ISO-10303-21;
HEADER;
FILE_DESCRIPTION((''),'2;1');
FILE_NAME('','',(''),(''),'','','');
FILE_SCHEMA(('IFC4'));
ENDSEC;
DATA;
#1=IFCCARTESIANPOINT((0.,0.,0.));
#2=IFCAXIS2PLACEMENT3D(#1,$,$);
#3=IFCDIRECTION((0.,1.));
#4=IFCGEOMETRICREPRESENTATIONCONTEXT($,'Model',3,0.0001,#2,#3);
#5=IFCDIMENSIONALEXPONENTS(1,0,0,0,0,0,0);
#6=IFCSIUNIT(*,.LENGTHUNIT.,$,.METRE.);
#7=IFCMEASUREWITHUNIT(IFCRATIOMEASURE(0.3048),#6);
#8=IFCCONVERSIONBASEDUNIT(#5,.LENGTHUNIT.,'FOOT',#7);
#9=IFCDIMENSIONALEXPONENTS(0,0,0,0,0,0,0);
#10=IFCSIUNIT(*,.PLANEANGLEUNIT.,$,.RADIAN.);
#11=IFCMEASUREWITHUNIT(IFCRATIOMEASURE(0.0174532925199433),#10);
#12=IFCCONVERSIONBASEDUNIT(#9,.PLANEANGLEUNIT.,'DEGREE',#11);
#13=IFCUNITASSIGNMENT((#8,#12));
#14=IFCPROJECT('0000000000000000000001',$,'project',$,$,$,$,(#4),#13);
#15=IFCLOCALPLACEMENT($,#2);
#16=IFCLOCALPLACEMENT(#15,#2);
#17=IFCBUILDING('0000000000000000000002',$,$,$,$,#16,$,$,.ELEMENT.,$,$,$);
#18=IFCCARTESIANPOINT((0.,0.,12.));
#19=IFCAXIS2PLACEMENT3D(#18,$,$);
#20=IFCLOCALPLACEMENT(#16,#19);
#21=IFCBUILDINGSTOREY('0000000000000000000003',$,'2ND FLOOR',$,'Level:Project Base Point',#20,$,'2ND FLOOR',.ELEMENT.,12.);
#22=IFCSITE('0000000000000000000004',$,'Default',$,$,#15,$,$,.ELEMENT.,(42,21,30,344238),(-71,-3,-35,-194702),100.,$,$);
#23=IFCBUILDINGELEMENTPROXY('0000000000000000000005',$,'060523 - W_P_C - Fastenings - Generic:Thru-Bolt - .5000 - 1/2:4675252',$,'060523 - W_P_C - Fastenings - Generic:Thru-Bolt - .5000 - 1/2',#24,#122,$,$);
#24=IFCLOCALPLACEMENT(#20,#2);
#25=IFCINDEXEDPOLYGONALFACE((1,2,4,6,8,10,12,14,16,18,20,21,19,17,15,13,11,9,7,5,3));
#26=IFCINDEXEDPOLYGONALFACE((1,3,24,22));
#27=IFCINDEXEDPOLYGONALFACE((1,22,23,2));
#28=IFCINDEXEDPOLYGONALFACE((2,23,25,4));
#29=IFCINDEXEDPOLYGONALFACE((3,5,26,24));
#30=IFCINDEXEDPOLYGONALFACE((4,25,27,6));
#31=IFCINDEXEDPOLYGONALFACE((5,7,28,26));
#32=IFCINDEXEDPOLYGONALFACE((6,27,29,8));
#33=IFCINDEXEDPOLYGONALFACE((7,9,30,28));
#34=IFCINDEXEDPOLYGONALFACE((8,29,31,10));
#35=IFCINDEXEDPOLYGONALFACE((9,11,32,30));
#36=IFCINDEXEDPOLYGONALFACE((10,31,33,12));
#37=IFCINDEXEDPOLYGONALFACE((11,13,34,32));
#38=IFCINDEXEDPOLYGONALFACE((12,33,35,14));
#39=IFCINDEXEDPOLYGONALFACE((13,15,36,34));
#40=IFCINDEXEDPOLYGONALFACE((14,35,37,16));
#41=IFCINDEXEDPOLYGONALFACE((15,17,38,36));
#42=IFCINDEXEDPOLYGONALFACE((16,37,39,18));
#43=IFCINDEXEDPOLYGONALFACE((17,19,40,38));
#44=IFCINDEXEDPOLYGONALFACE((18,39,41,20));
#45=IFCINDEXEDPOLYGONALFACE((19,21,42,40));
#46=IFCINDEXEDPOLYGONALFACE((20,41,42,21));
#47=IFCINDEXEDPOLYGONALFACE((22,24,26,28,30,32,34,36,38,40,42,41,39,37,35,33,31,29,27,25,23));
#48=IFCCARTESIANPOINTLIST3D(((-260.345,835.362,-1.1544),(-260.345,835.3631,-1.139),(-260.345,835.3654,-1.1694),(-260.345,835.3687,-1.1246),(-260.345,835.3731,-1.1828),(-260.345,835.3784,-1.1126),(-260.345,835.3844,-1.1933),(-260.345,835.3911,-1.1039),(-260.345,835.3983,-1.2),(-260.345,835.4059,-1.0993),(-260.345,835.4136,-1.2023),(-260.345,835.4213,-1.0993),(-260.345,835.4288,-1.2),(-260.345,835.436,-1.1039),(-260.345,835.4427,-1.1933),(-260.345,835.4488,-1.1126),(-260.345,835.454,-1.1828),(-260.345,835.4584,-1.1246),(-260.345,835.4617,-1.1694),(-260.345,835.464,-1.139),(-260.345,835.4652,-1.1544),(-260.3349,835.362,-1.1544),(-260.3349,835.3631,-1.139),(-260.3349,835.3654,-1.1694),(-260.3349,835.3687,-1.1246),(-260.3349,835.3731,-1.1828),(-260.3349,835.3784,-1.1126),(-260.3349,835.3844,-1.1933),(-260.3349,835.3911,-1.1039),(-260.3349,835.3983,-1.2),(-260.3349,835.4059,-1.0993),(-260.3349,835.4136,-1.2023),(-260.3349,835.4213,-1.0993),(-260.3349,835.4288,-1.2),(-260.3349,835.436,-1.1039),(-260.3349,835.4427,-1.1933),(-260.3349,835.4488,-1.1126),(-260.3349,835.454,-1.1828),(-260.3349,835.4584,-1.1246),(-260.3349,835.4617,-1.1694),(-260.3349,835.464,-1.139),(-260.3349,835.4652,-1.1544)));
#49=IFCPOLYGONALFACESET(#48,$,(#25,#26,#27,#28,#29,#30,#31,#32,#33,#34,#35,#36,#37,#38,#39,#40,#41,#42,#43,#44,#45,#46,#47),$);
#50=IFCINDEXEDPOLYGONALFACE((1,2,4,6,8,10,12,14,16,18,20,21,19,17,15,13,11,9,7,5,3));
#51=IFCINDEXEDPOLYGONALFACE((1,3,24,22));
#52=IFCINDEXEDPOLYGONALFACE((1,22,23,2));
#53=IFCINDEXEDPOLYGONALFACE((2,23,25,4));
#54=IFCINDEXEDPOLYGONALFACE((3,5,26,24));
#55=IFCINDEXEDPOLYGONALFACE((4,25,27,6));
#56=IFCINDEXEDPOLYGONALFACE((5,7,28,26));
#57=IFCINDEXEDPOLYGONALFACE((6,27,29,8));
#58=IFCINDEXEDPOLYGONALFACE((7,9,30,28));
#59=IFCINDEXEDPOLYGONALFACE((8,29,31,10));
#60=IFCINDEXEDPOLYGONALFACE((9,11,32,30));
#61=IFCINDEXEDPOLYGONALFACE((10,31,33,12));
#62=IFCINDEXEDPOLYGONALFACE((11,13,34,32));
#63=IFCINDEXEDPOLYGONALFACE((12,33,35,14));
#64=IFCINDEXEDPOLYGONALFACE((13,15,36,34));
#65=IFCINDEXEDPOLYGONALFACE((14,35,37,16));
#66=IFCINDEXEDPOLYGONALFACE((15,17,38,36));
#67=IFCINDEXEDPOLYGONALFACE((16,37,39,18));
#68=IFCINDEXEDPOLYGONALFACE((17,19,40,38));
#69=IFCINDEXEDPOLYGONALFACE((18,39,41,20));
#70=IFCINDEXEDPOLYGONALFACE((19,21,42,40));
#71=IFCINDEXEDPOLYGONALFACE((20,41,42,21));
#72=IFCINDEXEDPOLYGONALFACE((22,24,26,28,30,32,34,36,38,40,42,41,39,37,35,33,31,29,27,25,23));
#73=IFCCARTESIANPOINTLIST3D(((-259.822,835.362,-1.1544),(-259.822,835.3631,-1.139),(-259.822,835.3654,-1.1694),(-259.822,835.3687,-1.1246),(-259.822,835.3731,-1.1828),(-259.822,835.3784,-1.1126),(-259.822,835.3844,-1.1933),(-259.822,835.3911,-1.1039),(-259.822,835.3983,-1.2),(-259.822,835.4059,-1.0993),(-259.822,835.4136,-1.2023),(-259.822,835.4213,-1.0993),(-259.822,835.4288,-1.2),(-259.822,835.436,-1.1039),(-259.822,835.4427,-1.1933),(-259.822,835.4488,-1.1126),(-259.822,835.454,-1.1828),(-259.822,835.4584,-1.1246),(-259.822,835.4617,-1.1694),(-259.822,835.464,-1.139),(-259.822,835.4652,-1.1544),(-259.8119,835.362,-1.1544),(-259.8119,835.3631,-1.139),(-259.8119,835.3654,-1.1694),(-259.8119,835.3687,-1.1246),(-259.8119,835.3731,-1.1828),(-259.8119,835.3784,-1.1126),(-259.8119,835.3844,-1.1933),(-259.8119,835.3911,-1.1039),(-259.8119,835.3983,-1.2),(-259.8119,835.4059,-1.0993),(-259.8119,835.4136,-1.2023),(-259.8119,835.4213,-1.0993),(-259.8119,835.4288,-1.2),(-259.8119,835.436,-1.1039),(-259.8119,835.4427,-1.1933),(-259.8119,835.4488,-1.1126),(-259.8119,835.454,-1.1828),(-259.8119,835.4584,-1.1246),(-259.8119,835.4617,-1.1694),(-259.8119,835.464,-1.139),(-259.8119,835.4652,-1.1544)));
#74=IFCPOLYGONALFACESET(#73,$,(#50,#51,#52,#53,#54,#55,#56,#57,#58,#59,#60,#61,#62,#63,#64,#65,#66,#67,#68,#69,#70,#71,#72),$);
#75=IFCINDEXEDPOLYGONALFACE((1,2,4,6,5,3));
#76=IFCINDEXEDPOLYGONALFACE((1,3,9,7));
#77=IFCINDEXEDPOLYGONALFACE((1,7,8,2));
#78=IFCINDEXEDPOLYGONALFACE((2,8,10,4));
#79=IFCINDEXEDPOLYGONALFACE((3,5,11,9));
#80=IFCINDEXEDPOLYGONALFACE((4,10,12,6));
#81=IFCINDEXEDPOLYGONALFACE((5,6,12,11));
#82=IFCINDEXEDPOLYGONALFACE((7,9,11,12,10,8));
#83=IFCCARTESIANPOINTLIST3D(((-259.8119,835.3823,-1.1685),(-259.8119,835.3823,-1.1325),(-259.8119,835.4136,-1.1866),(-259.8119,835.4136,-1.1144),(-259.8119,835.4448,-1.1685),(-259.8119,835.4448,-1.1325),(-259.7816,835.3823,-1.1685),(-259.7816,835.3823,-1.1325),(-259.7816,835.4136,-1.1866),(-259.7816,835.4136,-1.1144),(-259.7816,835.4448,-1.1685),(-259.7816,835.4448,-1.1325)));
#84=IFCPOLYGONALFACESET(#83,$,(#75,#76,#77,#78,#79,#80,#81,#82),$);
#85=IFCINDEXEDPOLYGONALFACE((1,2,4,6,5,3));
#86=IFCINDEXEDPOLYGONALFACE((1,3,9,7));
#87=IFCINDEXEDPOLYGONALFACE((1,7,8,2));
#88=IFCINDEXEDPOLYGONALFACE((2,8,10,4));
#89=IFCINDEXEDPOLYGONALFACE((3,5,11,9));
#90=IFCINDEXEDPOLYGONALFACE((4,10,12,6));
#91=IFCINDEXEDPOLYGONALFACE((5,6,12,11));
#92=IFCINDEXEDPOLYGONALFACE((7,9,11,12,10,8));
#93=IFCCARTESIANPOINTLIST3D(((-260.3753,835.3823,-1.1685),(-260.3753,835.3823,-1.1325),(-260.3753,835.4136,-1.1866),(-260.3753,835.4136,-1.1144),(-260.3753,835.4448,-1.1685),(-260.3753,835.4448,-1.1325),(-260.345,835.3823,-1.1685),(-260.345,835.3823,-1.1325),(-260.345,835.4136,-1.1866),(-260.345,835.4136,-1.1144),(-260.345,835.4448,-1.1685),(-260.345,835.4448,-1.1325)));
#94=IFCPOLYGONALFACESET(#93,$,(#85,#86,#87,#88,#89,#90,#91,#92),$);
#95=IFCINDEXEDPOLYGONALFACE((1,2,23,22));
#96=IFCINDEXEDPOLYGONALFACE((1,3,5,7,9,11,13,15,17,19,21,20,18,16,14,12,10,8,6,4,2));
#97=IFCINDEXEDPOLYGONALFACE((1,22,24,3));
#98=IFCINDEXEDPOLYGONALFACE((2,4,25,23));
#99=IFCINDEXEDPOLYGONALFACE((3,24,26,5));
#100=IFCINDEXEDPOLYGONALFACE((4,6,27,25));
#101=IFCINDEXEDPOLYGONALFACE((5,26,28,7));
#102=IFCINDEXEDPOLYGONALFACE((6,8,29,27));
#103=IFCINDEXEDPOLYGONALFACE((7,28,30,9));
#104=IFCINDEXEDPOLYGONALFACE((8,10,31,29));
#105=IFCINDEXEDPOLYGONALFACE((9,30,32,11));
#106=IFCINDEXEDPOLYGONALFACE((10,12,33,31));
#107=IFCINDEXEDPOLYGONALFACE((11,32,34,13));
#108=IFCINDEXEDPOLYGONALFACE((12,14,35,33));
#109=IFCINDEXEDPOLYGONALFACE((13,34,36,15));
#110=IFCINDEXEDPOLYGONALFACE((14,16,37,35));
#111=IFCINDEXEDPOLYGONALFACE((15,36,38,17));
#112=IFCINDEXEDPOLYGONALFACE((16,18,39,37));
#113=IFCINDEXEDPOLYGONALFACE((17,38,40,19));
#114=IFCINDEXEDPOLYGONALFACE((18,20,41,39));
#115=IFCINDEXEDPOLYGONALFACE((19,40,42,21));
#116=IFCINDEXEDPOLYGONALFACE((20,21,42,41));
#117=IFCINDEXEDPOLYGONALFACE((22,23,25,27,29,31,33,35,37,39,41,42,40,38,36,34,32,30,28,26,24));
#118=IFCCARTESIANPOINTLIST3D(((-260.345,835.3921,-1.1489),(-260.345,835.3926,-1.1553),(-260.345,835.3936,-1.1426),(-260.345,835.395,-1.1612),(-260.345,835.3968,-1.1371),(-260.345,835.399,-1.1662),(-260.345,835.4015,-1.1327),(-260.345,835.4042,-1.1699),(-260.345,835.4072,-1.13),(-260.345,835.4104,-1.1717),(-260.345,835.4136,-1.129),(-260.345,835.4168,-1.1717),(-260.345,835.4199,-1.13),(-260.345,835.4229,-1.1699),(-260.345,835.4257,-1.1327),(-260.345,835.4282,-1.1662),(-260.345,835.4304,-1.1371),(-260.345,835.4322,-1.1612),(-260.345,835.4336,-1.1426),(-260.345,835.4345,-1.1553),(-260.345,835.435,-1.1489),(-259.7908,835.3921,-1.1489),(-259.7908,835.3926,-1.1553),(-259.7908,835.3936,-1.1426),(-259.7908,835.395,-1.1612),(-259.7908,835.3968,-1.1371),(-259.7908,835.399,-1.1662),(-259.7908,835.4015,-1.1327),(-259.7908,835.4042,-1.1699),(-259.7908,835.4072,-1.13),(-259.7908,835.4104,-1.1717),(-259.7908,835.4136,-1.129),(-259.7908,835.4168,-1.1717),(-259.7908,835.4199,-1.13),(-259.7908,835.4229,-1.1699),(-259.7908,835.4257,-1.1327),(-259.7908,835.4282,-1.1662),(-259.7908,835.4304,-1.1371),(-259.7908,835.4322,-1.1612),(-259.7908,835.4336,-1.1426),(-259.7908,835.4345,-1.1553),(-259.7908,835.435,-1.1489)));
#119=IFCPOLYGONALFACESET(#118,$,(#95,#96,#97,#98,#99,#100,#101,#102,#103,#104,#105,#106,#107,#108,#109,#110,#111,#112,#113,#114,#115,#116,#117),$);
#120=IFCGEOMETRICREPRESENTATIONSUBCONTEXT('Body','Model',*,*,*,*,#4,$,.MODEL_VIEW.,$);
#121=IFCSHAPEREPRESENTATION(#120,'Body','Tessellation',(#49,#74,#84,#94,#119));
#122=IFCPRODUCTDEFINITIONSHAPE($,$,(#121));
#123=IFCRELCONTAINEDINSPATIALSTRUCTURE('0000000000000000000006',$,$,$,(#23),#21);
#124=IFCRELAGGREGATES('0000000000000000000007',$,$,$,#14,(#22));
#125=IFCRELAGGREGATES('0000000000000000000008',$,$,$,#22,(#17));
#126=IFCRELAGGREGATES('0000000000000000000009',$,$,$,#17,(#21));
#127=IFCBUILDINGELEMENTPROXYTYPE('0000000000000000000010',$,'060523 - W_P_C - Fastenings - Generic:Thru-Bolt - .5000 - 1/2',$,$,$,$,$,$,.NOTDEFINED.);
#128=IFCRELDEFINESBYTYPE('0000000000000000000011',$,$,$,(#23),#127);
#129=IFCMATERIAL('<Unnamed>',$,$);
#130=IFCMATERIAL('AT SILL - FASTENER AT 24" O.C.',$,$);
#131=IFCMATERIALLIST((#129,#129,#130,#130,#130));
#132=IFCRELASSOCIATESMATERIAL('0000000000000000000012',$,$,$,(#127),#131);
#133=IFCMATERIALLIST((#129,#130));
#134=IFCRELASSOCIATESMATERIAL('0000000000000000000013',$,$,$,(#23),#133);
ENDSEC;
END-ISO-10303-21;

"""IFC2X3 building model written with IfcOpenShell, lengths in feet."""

from ifc_helpers import new_model, entity, si_unit, converted_unit, direction, frame, frame_2d, origin, place, context, subcontext, project, spatial, polyline, circle, outline, extrude, source, transform, mapped, material, material_list, type_object, type_shapes, element, save


model = new_model("IFC2X3")

# Units and contexts
model_context = context("Model", 3, precision=0.0001, world=origin(), true_north=direction((0.0, 1.0)))
body_context = subcontext(model_context, "Body", "Model", "MODEL_VIEW")
ifc_project = project(units=[converted_unit("LENGTHUNIT", "FOOT", entity("IfcRatioMeasure", 0.3048), si_unit("LENGTHUNIT", "METRE"), dimensions=[1, 0, 0, 0, 0, 0, 0]), converted_unit("PLANEANGLEUNIT", "DEGREE", entity("IfcRatioMeasure", 0.0174532925199433), si_unit("PLANEANGLEUNIT", "RADIAN"), dimensions=[0, 0, 0, 0, 0, 0, 0])], contexts=[model_context])

# Site, building, storey
site_placement = place(None, origin())
site = spatial("IfcSite", under=ifc_project, at=site_placement, Name="Default", CompositionType="ELEMENT", RefLatitude=(42, 21, 30, 344238), RefLongitude=(-71, -3, -35, -194702), RefElevation=100.0)
building_placement = place(site_placement, origin())
building = spatial("IfcBuilding", under=site, at=building_placement, CompositionType="ELEMENT")
storey_placement = place(building_placement, frame((0.0, 0.0, 12.0)))
storey = spatial("IfcBuildingStorey", under=building, at=storey_placement, Name="2ND FLOOR", ObjectType="Level:Project Base Point", LongName="2ND FLOOR", CompositionType="ELEMENT", Elevation=12.0)

# Building element proxy
ifc_material_1 = material(Name="<Unnamed>")
ifc_material_2 = material(Name="AT SILL - FASTENER AT 24\" O.C.")
ifc_material_list_1 = material_list([ifc_material_1, ifc_material_1, ifc_material_2, ifc_material_2, ifc_material_2])
building_element_proxy_type_1 = type_object("IfcBuildingElementProxyType", Name="060523 - W_P_C - Fastenings - Generic:Thru-Bolt - .5000 - 1/2", PredefinedType="NOTDEFINED", material=ifc_material_list_1)
shared_shape_1 = source(origin(), body_context, "Body", "SweptSolid", [
    extrude(circle(Radius=0.0518, at=frame_2d((0.0, 0.0), x_axis=(1.0, 0.0))), frame((0.0, 0.0, 0.0), z_axis=(0.0, 0.0, 1.0), x_axis=(0.0, -1.0, 0.0)), (0.0, 0.0, 1.0), 0.0101),
    extrude(circle(Radius=0.0518, at=frame_2d((0.0, 0.0), x_axis=(1.0, 0.0))), frame((0.0, 0.0, -0.523), z_axis=(0.0, 0.0, 1.0), x_axis=(0.0, -1.0, 0.0)), (0.0, 0.0, 1.0), 0.0101),
    extrude(outline(polyline([(-0.018, -0.0313), (0.018, -0.0313), (0.0361, 0.0), (0.018, 0.0312), (-0.018, 0.0312), (-0.0361, 0.0), (-0.018, -0.0313)])), frame((0.0, 0.0, -0.5533), z_axis=(0.0, 0.0, 1.0), x_axis=(0.866025, -0.5, 0.0)), (0.0, 0.0, 1.0), 0.0303),
    extrude(outline(polyline([(-0.018, -0.0313), (0.018, -0.0313), (0.0361, 0.0), (0.018, 0.0313), (-0.018, 0.0313), (-0.0361, 0.0), (-0.018, -0.0313)])), frame((0.0, 0.0, 0.0101), z_axis=(0.0, 0.0, 1.0), x_axis=(0.0, -1.0, 0.0)), (0.0, 0.0, 1.0), 0.0303),
    extrude(circle(Radius=0.0215, at=frame_2d((0.0, 0.0), x_axis=(1.0, 0.0))), frame((0.0, 0.0, -0.5442), z_axis=(0.0, 0.0, 1.0), x_axis=(0.0, 1.0, 0.0)), (0.0, 0.0, 1.0), 0.5543),
])
type_shapes(building_element_proxy_type_1, [shared_shape_1])
ifc_material_list_2 = material_list([ifc_material_1, ifc_material_2])
proxy_1_placement = place(storey_placement, frame((-260.3349, 835.4136, -1.1505), z_axis=(-1.0, 0.0, 0.0), x_axis=(0.0, -1.0, 0.0)))
element("IfcBuildingElementProxy", 1, at=proxy_1_placement, inside=storey, type_object=building_element_proxy_type_1, material=ifc_material_list_2, Name="060523 - W_P_C - Fastenings - Generic:Thru-Bolt - .5000 - 1/2:4675252", ObjectType="060523 - W_P_C - Fastenings - Generic:Thru-Bolt - .5000 - 1/2", context=body_context, shape_type="MappedRepresentation", body=[
    mapped(shared_shape_1, transform((0.0, 0.0, 0.0), scale=1.0)),
])

save(model, "model.ifc")
